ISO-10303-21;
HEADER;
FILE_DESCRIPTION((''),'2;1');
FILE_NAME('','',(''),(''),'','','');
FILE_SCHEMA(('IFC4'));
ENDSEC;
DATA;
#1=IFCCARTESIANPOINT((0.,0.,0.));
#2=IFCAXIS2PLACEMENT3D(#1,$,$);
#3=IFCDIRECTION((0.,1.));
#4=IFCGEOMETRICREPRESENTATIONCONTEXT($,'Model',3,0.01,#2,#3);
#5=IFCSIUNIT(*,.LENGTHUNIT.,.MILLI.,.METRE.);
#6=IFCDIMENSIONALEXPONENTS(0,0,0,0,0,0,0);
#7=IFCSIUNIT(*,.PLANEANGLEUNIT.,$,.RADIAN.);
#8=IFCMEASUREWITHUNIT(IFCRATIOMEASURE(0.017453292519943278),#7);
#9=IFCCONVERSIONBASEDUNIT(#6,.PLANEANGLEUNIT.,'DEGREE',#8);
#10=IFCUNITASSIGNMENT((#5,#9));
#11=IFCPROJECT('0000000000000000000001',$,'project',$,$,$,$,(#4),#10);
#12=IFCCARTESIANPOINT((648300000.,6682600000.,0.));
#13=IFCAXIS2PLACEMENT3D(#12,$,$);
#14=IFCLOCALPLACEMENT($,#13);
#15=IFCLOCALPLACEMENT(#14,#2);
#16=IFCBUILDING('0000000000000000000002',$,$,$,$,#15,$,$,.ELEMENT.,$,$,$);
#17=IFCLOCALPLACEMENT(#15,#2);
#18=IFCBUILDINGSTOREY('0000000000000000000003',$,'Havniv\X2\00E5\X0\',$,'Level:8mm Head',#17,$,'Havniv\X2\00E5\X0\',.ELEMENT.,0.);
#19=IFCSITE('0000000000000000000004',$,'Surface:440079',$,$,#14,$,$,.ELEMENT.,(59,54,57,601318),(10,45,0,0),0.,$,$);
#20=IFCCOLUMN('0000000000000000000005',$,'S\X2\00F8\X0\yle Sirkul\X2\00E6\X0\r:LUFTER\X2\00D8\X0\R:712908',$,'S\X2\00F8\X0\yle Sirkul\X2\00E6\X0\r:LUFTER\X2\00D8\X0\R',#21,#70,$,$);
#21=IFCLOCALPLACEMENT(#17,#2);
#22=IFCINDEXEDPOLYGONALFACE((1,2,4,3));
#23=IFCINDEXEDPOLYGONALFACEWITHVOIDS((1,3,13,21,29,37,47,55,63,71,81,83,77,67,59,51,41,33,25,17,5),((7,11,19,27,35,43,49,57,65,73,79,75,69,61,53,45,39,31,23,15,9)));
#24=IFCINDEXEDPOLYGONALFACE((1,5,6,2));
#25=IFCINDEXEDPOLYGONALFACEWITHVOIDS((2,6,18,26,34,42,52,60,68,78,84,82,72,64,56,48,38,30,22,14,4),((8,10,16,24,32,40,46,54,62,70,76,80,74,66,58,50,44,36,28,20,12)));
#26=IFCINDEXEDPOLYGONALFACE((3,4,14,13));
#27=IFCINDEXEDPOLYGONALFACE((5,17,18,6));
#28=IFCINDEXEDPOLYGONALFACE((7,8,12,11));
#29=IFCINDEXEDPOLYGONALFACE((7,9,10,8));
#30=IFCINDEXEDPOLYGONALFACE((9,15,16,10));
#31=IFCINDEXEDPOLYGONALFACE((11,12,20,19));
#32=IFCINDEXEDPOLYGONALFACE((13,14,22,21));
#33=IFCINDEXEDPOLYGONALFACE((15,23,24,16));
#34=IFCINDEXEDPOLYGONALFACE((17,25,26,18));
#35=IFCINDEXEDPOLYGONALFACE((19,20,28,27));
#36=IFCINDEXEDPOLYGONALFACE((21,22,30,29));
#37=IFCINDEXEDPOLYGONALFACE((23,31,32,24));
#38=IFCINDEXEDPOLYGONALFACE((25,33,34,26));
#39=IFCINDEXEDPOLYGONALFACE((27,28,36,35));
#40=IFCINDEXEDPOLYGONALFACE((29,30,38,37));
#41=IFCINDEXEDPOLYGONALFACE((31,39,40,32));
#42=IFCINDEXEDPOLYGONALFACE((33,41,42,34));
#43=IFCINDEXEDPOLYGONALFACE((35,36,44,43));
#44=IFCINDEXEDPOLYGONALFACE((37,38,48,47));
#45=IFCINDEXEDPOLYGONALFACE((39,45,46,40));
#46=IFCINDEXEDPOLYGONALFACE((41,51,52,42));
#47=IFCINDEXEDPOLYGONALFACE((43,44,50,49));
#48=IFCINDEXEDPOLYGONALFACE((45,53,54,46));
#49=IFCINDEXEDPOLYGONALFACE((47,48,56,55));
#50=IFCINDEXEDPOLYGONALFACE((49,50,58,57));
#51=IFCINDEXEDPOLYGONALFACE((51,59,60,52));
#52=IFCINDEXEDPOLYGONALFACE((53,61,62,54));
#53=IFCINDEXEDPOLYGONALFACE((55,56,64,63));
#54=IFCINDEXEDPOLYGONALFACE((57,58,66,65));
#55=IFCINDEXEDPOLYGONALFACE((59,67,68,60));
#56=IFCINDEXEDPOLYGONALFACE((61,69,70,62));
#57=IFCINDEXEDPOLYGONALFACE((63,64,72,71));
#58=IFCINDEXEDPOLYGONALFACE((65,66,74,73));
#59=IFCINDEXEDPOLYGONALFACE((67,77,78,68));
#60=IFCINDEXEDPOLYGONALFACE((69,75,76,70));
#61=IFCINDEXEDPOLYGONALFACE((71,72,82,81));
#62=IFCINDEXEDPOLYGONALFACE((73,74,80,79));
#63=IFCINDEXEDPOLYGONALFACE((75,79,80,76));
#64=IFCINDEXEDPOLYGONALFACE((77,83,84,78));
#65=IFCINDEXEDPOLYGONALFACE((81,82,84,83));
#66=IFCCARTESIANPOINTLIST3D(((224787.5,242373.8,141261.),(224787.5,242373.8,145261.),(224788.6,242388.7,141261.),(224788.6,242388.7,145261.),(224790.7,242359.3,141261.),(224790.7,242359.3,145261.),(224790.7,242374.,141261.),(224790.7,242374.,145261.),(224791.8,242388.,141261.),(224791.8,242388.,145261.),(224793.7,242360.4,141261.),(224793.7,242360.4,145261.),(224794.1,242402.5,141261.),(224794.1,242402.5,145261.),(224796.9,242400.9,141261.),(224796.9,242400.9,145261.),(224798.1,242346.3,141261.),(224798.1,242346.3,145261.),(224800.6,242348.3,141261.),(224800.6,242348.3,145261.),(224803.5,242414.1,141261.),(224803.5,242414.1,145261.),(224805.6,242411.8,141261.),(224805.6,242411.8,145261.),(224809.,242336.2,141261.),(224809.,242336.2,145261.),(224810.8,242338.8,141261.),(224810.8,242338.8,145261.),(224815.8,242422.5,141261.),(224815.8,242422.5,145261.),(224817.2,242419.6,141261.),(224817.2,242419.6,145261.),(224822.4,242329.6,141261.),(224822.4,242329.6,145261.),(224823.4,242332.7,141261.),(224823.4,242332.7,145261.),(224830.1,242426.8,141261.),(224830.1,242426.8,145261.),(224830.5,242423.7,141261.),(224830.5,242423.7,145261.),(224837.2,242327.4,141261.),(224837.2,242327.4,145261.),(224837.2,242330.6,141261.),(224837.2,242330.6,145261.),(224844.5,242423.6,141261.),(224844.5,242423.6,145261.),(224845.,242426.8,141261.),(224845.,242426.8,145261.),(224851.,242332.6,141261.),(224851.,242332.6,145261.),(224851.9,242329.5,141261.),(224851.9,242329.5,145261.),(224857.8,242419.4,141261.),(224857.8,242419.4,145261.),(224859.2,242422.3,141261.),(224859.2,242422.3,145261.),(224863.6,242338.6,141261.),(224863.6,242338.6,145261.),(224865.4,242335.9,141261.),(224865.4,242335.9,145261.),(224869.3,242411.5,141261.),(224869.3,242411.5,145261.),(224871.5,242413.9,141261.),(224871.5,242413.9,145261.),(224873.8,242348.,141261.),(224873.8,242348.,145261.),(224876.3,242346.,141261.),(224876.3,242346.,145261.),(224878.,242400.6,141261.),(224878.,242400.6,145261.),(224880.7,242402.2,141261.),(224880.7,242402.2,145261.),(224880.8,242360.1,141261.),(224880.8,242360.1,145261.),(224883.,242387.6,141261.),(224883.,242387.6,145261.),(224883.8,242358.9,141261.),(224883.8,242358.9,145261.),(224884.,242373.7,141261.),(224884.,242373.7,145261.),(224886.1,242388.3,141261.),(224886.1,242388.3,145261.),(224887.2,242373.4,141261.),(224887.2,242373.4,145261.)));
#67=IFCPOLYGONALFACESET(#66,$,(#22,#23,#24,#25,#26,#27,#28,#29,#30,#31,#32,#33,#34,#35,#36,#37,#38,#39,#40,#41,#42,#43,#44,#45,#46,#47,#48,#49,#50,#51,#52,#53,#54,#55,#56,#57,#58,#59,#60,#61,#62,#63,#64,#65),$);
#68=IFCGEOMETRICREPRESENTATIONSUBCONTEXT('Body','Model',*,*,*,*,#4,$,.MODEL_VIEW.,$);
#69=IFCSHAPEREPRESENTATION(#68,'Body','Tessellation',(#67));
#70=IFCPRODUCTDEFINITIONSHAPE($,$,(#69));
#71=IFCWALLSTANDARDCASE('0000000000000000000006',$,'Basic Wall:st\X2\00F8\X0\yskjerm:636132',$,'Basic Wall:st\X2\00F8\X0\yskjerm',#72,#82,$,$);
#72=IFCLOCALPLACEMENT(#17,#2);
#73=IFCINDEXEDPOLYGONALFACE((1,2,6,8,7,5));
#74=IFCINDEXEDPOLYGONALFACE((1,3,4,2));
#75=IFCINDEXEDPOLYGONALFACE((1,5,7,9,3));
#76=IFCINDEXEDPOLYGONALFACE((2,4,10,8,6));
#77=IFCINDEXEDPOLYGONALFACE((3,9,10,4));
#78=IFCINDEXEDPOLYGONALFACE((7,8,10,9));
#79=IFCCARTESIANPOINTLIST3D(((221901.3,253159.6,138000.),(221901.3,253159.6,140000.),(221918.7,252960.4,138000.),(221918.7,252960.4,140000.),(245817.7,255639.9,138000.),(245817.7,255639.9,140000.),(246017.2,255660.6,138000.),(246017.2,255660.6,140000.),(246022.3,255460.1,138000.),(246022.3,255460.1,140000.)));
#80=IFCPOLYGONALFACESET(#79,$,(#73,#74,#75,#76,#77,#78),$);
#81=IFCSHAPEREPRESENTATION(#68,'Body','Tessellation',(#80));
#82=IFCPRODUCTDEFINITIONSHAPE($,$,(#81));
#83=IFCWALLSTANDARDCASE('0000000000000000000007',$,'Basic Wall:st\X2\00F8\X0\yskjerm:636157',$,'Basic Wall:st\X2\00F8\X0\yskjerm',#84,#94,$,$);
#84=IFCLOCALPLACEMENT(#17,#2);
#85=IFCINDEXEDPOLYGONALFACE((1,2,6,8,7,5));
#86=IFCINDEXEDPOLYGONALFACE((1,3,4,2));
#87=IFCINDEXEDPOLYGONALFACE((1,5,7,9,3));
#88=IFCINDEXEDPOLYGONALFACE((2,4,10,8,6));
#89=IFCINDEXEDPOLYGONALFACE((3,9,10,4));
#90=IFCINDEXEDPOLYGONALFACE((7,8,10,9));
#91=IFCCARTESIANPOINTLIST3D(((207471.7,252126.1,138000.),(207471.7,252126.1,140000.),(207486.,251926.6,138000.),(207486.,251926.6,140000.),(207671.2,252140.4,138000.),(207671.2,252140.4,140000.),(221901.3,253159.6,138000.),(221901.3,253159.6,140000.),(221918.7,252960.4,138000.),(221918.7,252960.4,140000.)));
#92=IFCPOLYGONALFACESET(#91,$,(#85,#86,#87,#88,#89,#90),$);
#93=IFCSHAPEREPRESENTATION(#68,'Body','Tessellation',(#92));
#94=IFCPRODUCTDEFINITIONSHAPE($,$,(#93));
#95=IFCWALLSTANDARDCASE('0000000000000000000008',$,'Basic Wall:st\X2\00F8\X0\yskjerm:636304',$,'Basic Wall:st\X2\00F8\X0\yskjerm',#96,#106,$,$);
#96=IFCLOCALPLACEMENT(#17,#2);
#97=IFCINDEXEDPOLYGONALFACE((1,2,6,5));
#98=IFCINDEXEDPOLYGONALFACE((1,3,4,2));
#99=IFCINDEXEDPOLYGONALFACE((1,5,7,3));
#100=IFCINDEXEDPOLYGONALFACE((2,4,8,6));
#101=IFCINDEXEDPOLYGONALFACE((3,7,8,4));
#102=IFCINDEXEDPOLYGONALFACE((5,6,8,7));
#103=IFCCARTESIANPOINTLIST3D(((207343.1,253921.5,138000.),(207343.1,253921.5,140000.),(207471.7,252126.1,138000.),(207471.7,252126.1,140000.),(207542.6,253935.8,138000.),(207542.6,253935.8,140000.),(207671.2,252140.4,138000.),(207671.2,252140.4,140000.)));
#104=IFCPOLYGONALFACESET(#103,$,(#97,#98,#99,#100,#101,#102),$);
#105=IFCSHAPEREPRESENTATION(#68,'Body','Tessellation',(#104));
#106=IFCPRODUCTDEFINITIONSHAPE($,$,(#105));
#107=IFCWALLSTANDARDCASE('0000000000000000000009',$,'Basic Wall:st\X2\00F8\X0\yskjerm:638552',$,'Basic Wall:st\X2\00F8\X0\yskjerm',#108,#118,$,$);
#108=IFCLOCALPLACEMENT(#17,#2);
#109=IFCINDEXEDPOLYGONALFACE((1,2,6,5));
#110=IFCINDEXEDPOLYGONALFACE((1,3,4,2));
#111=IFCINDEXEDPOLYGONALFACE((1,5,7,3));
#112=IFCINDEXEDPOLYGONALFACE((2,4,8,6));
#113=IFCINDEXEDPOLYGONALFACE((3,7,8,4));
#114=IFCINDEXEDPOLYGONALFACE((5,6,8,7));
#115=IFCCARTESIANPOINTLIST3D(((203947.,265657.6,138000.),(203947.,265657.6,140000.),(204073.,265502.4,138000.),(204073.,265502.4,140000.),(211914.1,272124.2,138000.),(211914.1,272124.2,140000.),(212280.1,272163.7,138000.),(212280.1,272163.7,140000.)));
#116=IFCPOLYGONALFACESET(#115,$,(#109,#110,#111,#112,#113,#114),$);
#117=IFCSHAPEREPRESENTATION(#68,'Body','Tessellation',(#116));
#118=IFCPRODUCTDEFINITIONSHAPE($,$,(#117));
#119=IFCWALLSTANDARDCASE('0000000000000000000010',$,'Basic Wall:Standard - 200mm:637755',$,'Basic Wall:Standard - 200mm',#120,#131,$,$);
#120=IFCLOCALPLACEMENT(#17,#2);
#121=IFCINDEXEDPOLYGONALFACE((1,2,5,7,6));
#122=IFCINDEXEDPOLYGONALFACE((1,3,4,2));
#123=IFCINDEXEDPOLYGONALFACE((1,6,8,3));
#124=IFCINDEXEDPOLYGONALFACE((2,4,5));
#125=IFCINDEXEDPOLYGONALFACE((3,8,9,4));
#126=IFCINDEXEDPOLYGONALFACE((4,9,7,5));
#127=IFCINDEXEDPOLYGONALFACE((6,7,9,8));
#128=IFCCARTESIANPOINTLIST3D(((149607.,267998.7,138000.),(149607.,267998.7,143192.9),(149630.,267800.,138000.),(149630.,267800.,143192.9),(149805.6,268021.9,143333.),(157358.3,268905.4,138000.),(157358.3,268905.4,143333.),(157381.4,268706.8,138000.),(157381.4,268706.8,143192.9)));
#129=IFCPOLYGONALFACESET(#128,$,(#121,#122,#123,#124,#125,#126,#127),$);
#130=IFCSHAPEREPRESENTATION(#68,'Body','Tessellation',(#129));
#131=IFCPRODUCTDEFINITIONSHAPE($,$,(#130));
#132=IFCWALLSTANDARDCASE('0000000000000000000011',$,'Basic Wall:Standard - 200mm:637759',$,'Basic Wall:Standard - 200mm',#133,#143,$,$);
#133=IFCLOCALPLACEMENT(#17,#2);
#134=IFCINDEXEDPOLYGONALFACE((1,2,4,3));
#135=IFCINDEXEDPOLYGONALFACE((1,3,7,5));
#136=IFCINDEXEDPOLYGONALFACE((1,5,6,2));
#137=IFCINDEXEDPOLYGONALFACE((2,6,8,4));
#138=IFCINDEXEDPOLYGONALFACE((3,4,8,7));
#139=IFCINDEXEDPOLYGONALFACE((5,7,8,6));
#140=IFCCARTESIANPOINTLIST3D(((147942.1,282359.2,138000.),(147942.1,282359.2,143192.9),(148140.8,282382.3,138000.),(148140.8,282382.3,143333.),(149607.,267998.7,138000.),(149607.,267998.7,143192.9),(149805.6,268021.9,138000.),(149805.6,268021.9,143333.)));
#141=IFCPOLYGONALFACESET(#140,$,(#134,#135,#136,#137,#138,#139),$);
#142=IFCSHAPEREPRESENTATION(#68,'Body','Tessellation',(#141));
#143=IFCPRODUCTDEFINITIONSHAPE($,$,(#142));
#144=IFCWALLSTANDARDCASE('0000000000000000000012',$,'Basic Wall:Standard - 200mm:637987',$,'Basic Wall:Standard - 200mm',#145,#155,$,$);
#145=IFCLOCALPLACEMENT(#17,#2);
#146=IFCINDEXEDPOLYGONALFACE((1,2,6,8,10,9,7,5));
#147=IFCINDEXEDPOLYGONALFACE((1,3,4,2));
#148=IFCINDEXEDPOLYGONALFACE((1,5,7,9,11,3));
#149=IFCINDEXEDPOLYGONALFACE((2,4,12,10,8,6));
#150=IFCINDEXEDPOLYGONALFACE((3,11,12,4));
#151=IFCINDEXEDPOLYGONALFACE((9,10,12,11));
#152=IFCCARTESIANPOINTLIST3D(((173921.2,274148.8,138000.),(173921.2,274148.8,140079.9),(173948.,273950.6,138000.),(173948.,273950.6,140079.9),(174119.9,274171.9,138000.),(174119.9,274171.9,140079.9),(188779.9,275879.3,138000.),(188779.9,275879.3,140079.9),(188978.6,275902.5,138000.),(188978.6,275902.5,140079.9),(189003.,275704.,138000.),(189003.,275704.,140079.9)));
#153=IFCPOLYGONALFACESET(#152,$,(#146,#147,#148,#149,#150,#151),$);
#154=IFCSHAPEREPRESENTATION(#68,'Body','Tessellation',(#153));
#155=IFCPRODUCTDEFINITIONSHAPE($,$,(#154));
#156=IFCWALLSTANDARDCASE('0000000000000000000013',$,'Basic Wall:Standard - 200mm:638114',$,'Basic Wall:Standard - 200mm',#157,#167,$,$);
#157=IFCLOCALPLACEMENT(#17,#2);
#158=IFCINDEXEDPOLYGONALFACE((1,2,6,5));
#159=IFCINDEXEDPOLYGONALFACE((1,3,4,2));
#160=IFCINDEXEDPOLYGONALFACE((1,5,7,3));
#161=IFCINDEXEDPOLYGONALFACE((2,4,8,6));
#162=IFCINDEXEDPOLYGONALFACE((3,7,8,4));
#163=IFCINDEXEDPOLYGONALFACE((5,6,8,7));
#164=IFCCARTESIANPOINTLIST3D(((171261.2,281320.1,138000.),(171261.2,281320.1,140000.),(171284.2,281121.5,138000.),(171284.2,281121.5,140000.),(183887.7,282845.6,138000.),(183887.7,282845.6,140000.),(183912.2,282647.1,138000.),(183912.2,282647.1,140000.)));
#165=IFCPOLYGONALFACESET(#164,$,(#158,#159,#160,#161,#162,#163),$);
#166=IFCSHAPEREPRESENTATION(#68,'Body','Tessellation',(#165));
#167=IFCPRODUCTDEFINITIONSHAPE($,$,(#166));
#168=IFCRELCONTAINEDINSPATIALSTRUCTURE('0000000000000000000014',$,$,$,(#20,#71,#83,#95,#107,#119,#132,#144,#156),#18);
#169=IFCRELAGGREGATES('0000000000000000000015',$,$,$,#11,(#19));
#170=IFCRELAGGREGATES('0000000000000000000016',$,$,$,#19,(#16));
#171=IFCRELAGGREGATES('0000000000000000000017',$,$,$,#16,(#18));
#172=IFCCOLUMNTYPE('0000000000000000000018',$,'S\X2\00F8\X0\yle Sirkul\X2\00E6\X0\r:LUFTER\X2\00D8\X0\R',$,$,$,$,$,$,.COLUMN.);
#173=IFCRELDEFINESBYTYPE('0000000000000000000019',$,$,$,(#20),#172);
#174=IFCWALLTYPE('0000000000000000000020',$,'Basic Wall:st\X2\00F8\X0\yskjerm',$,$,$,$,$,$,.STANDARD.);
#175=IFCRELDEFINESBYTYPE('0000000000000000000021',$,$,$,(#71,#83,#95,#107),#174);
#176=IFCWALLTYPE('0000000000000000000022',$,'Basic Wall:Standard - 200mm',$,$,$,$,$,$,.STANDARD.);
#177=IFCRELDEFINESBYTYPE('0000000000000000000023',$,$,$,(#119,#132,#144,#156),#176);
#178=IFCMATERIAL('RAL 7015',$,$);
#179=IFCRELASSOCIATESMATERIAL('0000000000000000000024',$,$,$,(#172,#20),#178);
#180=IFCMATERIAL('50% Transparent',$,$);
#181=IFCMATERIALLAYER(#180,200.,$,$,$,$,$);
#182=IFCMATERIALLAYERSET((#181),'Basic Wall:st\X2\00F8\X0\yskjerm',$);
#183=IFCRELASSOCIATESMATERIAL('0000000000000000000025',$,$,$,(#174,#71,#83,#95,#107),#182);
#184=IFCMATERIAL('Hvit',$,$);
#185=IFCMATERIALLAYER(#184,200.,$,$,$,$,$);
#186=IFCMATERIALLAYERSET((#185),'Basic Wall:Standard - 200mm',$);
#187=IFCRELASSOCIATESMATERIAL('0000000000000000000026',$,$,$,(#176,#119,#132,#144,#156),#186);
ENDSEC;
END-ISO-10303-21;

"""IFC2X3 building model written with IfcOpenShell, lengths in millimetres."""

from ifc_helpers import new_model, entity, si_unit, converted_unit, direction, frame, frame_2d, origin, place, context, subcontext, project, spatial, polyline, rectangle, hollow_circle, outline, extrude, clip, bounded_halfspace, source, transform, mapped, material, layer, layer_set, layer_usage, type_object, type_shapes, element, save


model = new_model("IFC2X3")

# Units and contexts
model_context = context("Model", 3, precision=0.01, world=origin(), true_north=direction((0.0, 1.0)))
body_context = subcontext(model_context, "Body", "Model", "MODEL_VIEW")
ifc_project = project(units=[si_unit("LENGTHUNIT", "METRE", prefix="MILLI"), converted_unit("PLANEANGLEUNIT", "DEGREE", entity("IfcRatioMeasure", 0.017453292519943278), si_unit("PLANEANGLEUNIT", "RADIAN"), dimensions=[0, 0, 0, 0, 0, 0, 0])], contexts=[model_context])

# Site, building, storey
site_placement = place(None, frame((648300000.0, 6682600000.0, 0.0)))
site = spatial("IfcSite", under=ifc_project, at=site_placement, Name="Surface:440079", CompositionType="ELEMENT", RefLatitude=(59, 54, 57, 601318), RefLongitude=(10, 45, 0, 0), RefElevation=0.0)
building_placement = place(site_placement, origin())
building = spatial("IfcBuilding", under=site, at=building_placement, CompositionType="ELEMENT")
storey_placement = place(building_placement, origin())
storey = spatial("IfcBuildingStorey", under=building, at=storey_placement, Name="Havnivå", ObjectType="Level:8mm Head", LongName="Havnivå", CompositionType="ELEMENT", Elevation=0.0)

# Column
ifc_material_1 = material(Name="RAL 7015")
column_type_1 = type_object("IfcColumnType", Name="Søyle Sirkulær:LUFTERØR", PredefinedType="COLUMN", material=ifc_material_1)
shared_shape_1 = source(origin(), body_context, "Body", "SweptSolid", [
    extrude(hollow_circle(Radius=50.0, WallThickness=3.2, at=frame_2d((0.0, 0.0), x_axis=(1.0, 0.0))), frame((-0.2, 0.2, 141261.0)), (0.0, 0.0, 1.0), 4000.0),
])
type_shapes(column_type_1, [shared_shape_1])
column_placement = place(storey_placement, frame((224837.1, 242377.5, 0.0), z_axis=(0.0, 0.0, 1.0), x_axis=(-0.997483, -0.070908, 0.0)))
element("IfcColumn", 1, at=column_placement, inside=storey, type_object=column_type_1, material=ifc_material_1, Name="Søyle Sirkulær:LUFTERØR:712908", ObjectType="Søyle Sirkulær:LUFTERØR", context=body_context, shape_type="MappedRepresentation", body=[
    mapped(shared_shape_1, transform((0.0, 0.0, 0.0), scale=1.0)),
])

# Walls
ifc_material_2 = material(Name="50% Transparent")
ifc_layer_1 = layer(ifc_material_2, 200.0)
ifc_layer_set_1 = layer_set([ifc_layer_1], Name="Basic Wall:støyskjerm")
ifc_layer_usage_1 = layer_usage(ifc_layer_set_1, "AXIS2", "NEGATIVE", 100.0)
wall_type_1 = type_object("IfcWallType", Name="Basic Wall:støyskjerm", PredefinedType="STANDARD", material=ifc_layer_set_1)
wall_1_placement = place(storey_placement, frame((221908.4, 253059.8, 138000.0), z_axis=(0.0, 0.0, 1.0), x_axis=(0.994665, 0.103154, 0.0)))
element("IfcWallStandardCase", 2, at=wall_1_placement, inside=storey, type_object=wall_type_1, material=ifc_layer_usage_1, Name="Basic Wall:støyskjerm:636132", ObjectType="Basic Wall:støyskjerm", context=body_context, shape_type="SweptSolid", body=[
    extrude(outline(polyline([(24232.9, -100.0), (24248.5, 100.0), (24047.9, 100.0), (3.2, 100.0), (0.0, -100.0), (24232.9, -100.0)])), origin(), (0.0, 0.0, 1.0), 2000.0),
])
ifc_layer_usage_2 = layer_usage(ifc_layer_set_1, "AXIS2", "NEGATIVE", 100.0)
wall_2_placement = place(storey_placement, frame((207478.8, 252026.4, 138000.0), z_axis=(0.0, 0.0, 1.0), x_axis=(0.997445, 0.071441, 0.0)))
element("IfcWallStandardCase", 3, at=wall_2_placement, inside=storey, type_object=wall_type_1, material=ifc_layer_usage_2, Name="Basic Wall:støyskjerm:636157", ObjectType="Basic Wall:støyskjerm", context=body_context, shape_type="SweptSolid", body=[
    extrude(outline(polyline([(14469.7, -100.0), (14466.6, 100.0), (200.0, 100.0), (0.0, 100.0), (0.0, -100.0), (14469.7, -100.0)])), origin(), (0.0, 0.0, 1.0), 2000.0),
])
ifc_layer_usage_3 = layer_usage(ifc_layer_set_1, "AXIS2", "NEGATIVE", 100.0)
wall_3_placement = place(storey_placement, frame((207442.8, 253928.7, 138000.0), z_axis=(0.0, 0.0, 1.0), x_axis=(0.071441, -0.997445, 0.0)))
element("IfcWallStandardCase", 4, at=wall_3_placement, inside=storey, type_object=wall_type_1, material=ifc_layer_usage_3, Name="Basic Wall:støyskjerm:636304", ObjectType="Basic Wall:støyskjerm", context=body_context, shape_type="SweptSolid", body=[
    extrude(rectangle(XDim=1800.0, YDim=200.0, at=frame_2d((900.0, 0.0), x_axis=(-1.0, 0.0))), origin(), (0.0, 0.0, 1.0), 2000.0),
])
ifc_layer_usage_4 = layer_usage(ifc_layer_set_1, "AXIS2", "NEGATIVE", 100.0)
wall_4_placement = place(storey_placement, frame((212217.1, 272241.4, 138000.0), z_axis=(0.0, 0.0, 1.0), x_axis=(-0.776431, -0.630202, 0.0)))
element("IfcWallStandardCase", 5, at=wall_4_placement, inside=storey, type_object=wall_type_1, material=ifc_layer_usage_4, Name="Basic Wall:støyskjerm:638552", ObjectType="Basic Wall:støyskjerm", context=body_context, shape_type="SweptSolid", body=[
    extrude(outline(polyline([(10570.2, -100.0), (10570.2, 100.0), (0.0, 100.0), (309.1, -100.0), (10570.2, -100.0)])), origin(), (0.0, 0.0, 1.0), 2000.0),
])
ifc_material_3 = material(Name="Hvit")
ifc_layer_2 = layer(ifc_material_3, 200.0)
ifc_layer_set_2 = layer_set([ifc_layer_2], Name="Basic Wall:Standard - 200mm")
wall_type_2 = type_object("IfcWallType", Name="Basic Wall:Standard - 200mm", PredefinedType="STANDARD", material=ifc_layer_set_2)
ifc_layer_usage_5 = layer_usage(ifc_layer_set_2, "AXIS2", "POSITIVE", -100.0)
wall_5_placement = place(storey_placement, frame((149618.4, 267899.3, 138000.0), z_axis=(0.0, 0.0, 1.0), x_axis=(0.993227, 0.116189, 0.0)))
element("IfcWallStandardCase", 6, at=wall_5_placement, inside=storey, type_object=wall_type_2, material=ifc_layer_usage_5, Name="Basic Wall:Standard - 200mm:637755", ObjectType="Basic Wall:Standard - 200mm", context=body_context, shape_type="Clipping", body=[
    clip(clip(extrude(outline(polyline([(7804.2, -100.0), (7804.4, 100.0), (200.2, 100.0), (0.2, 100.0), (0.0, -100.0), (7804.2, -100.0)])), origin(), (0.0, 0.0, 1.0), 5333.0), bounded_halfspace(frame((0.0, -100.0, 5192.9), z_axis=(0.0, -0.573576, 0.819152), x_axis=(1.0, 0.0, 0.0)), False, frame((0.0, -100.0, 5192.9)), polyline([(0.0, 0.0), (2378723.6, 0.0), (2378770.1, 60960.0), (61023.1, 60960.0), (0.0, 0.0)]))), bounded_halfspace(frame((200.2, 100.0, 5333.0), z_axis=(-0.573576, 0.000594, 0.819152), x_axis=(-0.001035, -0.999999, 0.0)), False, frame((200.2, 100.0, 5333.0)), polyline([(0.0, 0.0), (-60960.0, 0.0), (-61023.1, -60960.0), (0.0, 0.0)]))),
])
ifc_layer_usage_6 = layer_usage(ifc_layer_set_2, "AXIS2", "POSITIVE", -100.0)
wall_6_placement = place(storey_placement, frame((148041.5, 282370.7, 138000.0), z_axis=(0.0, 0.0, 1.0), x_axis=(0.115161, -0.993347, 0.0)))
element("IfcWallStandardCase", 7, at=wall_6_placement, inside=storey, type_object=wall_type_2, material=ifc_layer_usage_6, Name="Basic Wall:Standard - 200mm:637759", ObjectType="Basic Wall:Standard - 200mm", context=body_context, shape_type="Clipping", body=[
    clip(extrude(outline(polyline([(14456.7, -100.0), (14456.5, 100.0), (0.0, 100.0), (0.0, -100.0), (14456.7, -100.0)])), origin(), (0.0, 0.0, 1.0), 5333.0), bounded_halfspace(frame((0.0, -100.0, 5192.9), z_axis=(0.0, -0.573576, 0.819152), x_axis=(1.0, 0.0, 0.0)), False, frame((0.0, -100.0, 5192.9)), polyline([(0.0, 0.0), (4406416.4, 0.0), (4406353.3, 60960.0), (3.8, 60960.0), (0.0, 0.0)]))),
])
ifc_layer_usage_7 = layer_usage(ifc_layer_set_2, "AXIS2", "NEGATIVE", 100.0)
wall_7_placement = place(storey_placement, frame((188991.4, 275803.3, 138000.0), z_axis=(0.0, 0.0, 1.0), x_axis=(-0.993286, -0.115684, 0.0)))
element("IfcWallStandardCase", 8, at=wall_7_placement, inside=storey, type_object=wall_type_2, material=ifc_layer_usage_7, Name="Basic Wall:Standard - 200mm:637987", ObjectType="Basic Wall:Standard - 200mm", context=body_context, shape_type="SweptSolid", body=[
    extrude(outline(polyline([(15160.4, -100.0), (15156.7, 100.0), (0.0, 100.0), (1.3, -100.0), (201.3, -100.0), (14960.4, -100.0), (15160.4, -100.0)])), origin(), (0.0, 0.0, 1.0), 2079.9),
])
ifc_layer_usage_8 = layer_usage(ifc_layer_set_2, "AXIS2", "NEGATIVE", 100.0)
wall_8_placement = place(storey_placement, frame((171272.2, 281220.8, 138000.0), z_axis=(0.0, 0.0, 1.0), x_axis=(0.992781, 0.119939, 0.0)))
element("IfcWallStandardCase", 9, at=wall_8_placement, inside=storey, type_object=wall_type_2, material=ifc_layer_usage_8, Name="Basic Wall:Standard - 200mm:638114", ObjectType="Basic Wall:Standard - 200mm", context=body_context, shape_type="Clipping", body=[
    clip(extrude(outline(polyline([(12719.8, -100.0), (12719.3, 100.0), (1.0, 100.0), (0.0, -100.0), (12719.8, -100.0)])), origin(), (0.0, 0.0, 1.0), 2000.0), bounded_halfspace(frame((0.0, -100.0, 2000.0), z_axis=(0.0, 0.0, 1.0), x_axis=(0.992781, -0.119939, 0.0)), False, frame((0.0, -100.0, 2000.0)), polyline([(0.0, 0.0), (3876981.5, 0.0), (3876849.8, 60960.0), (297.1, 60960.0), (0.0, 0.0)]))),
])

save(model, "model.ifc")
